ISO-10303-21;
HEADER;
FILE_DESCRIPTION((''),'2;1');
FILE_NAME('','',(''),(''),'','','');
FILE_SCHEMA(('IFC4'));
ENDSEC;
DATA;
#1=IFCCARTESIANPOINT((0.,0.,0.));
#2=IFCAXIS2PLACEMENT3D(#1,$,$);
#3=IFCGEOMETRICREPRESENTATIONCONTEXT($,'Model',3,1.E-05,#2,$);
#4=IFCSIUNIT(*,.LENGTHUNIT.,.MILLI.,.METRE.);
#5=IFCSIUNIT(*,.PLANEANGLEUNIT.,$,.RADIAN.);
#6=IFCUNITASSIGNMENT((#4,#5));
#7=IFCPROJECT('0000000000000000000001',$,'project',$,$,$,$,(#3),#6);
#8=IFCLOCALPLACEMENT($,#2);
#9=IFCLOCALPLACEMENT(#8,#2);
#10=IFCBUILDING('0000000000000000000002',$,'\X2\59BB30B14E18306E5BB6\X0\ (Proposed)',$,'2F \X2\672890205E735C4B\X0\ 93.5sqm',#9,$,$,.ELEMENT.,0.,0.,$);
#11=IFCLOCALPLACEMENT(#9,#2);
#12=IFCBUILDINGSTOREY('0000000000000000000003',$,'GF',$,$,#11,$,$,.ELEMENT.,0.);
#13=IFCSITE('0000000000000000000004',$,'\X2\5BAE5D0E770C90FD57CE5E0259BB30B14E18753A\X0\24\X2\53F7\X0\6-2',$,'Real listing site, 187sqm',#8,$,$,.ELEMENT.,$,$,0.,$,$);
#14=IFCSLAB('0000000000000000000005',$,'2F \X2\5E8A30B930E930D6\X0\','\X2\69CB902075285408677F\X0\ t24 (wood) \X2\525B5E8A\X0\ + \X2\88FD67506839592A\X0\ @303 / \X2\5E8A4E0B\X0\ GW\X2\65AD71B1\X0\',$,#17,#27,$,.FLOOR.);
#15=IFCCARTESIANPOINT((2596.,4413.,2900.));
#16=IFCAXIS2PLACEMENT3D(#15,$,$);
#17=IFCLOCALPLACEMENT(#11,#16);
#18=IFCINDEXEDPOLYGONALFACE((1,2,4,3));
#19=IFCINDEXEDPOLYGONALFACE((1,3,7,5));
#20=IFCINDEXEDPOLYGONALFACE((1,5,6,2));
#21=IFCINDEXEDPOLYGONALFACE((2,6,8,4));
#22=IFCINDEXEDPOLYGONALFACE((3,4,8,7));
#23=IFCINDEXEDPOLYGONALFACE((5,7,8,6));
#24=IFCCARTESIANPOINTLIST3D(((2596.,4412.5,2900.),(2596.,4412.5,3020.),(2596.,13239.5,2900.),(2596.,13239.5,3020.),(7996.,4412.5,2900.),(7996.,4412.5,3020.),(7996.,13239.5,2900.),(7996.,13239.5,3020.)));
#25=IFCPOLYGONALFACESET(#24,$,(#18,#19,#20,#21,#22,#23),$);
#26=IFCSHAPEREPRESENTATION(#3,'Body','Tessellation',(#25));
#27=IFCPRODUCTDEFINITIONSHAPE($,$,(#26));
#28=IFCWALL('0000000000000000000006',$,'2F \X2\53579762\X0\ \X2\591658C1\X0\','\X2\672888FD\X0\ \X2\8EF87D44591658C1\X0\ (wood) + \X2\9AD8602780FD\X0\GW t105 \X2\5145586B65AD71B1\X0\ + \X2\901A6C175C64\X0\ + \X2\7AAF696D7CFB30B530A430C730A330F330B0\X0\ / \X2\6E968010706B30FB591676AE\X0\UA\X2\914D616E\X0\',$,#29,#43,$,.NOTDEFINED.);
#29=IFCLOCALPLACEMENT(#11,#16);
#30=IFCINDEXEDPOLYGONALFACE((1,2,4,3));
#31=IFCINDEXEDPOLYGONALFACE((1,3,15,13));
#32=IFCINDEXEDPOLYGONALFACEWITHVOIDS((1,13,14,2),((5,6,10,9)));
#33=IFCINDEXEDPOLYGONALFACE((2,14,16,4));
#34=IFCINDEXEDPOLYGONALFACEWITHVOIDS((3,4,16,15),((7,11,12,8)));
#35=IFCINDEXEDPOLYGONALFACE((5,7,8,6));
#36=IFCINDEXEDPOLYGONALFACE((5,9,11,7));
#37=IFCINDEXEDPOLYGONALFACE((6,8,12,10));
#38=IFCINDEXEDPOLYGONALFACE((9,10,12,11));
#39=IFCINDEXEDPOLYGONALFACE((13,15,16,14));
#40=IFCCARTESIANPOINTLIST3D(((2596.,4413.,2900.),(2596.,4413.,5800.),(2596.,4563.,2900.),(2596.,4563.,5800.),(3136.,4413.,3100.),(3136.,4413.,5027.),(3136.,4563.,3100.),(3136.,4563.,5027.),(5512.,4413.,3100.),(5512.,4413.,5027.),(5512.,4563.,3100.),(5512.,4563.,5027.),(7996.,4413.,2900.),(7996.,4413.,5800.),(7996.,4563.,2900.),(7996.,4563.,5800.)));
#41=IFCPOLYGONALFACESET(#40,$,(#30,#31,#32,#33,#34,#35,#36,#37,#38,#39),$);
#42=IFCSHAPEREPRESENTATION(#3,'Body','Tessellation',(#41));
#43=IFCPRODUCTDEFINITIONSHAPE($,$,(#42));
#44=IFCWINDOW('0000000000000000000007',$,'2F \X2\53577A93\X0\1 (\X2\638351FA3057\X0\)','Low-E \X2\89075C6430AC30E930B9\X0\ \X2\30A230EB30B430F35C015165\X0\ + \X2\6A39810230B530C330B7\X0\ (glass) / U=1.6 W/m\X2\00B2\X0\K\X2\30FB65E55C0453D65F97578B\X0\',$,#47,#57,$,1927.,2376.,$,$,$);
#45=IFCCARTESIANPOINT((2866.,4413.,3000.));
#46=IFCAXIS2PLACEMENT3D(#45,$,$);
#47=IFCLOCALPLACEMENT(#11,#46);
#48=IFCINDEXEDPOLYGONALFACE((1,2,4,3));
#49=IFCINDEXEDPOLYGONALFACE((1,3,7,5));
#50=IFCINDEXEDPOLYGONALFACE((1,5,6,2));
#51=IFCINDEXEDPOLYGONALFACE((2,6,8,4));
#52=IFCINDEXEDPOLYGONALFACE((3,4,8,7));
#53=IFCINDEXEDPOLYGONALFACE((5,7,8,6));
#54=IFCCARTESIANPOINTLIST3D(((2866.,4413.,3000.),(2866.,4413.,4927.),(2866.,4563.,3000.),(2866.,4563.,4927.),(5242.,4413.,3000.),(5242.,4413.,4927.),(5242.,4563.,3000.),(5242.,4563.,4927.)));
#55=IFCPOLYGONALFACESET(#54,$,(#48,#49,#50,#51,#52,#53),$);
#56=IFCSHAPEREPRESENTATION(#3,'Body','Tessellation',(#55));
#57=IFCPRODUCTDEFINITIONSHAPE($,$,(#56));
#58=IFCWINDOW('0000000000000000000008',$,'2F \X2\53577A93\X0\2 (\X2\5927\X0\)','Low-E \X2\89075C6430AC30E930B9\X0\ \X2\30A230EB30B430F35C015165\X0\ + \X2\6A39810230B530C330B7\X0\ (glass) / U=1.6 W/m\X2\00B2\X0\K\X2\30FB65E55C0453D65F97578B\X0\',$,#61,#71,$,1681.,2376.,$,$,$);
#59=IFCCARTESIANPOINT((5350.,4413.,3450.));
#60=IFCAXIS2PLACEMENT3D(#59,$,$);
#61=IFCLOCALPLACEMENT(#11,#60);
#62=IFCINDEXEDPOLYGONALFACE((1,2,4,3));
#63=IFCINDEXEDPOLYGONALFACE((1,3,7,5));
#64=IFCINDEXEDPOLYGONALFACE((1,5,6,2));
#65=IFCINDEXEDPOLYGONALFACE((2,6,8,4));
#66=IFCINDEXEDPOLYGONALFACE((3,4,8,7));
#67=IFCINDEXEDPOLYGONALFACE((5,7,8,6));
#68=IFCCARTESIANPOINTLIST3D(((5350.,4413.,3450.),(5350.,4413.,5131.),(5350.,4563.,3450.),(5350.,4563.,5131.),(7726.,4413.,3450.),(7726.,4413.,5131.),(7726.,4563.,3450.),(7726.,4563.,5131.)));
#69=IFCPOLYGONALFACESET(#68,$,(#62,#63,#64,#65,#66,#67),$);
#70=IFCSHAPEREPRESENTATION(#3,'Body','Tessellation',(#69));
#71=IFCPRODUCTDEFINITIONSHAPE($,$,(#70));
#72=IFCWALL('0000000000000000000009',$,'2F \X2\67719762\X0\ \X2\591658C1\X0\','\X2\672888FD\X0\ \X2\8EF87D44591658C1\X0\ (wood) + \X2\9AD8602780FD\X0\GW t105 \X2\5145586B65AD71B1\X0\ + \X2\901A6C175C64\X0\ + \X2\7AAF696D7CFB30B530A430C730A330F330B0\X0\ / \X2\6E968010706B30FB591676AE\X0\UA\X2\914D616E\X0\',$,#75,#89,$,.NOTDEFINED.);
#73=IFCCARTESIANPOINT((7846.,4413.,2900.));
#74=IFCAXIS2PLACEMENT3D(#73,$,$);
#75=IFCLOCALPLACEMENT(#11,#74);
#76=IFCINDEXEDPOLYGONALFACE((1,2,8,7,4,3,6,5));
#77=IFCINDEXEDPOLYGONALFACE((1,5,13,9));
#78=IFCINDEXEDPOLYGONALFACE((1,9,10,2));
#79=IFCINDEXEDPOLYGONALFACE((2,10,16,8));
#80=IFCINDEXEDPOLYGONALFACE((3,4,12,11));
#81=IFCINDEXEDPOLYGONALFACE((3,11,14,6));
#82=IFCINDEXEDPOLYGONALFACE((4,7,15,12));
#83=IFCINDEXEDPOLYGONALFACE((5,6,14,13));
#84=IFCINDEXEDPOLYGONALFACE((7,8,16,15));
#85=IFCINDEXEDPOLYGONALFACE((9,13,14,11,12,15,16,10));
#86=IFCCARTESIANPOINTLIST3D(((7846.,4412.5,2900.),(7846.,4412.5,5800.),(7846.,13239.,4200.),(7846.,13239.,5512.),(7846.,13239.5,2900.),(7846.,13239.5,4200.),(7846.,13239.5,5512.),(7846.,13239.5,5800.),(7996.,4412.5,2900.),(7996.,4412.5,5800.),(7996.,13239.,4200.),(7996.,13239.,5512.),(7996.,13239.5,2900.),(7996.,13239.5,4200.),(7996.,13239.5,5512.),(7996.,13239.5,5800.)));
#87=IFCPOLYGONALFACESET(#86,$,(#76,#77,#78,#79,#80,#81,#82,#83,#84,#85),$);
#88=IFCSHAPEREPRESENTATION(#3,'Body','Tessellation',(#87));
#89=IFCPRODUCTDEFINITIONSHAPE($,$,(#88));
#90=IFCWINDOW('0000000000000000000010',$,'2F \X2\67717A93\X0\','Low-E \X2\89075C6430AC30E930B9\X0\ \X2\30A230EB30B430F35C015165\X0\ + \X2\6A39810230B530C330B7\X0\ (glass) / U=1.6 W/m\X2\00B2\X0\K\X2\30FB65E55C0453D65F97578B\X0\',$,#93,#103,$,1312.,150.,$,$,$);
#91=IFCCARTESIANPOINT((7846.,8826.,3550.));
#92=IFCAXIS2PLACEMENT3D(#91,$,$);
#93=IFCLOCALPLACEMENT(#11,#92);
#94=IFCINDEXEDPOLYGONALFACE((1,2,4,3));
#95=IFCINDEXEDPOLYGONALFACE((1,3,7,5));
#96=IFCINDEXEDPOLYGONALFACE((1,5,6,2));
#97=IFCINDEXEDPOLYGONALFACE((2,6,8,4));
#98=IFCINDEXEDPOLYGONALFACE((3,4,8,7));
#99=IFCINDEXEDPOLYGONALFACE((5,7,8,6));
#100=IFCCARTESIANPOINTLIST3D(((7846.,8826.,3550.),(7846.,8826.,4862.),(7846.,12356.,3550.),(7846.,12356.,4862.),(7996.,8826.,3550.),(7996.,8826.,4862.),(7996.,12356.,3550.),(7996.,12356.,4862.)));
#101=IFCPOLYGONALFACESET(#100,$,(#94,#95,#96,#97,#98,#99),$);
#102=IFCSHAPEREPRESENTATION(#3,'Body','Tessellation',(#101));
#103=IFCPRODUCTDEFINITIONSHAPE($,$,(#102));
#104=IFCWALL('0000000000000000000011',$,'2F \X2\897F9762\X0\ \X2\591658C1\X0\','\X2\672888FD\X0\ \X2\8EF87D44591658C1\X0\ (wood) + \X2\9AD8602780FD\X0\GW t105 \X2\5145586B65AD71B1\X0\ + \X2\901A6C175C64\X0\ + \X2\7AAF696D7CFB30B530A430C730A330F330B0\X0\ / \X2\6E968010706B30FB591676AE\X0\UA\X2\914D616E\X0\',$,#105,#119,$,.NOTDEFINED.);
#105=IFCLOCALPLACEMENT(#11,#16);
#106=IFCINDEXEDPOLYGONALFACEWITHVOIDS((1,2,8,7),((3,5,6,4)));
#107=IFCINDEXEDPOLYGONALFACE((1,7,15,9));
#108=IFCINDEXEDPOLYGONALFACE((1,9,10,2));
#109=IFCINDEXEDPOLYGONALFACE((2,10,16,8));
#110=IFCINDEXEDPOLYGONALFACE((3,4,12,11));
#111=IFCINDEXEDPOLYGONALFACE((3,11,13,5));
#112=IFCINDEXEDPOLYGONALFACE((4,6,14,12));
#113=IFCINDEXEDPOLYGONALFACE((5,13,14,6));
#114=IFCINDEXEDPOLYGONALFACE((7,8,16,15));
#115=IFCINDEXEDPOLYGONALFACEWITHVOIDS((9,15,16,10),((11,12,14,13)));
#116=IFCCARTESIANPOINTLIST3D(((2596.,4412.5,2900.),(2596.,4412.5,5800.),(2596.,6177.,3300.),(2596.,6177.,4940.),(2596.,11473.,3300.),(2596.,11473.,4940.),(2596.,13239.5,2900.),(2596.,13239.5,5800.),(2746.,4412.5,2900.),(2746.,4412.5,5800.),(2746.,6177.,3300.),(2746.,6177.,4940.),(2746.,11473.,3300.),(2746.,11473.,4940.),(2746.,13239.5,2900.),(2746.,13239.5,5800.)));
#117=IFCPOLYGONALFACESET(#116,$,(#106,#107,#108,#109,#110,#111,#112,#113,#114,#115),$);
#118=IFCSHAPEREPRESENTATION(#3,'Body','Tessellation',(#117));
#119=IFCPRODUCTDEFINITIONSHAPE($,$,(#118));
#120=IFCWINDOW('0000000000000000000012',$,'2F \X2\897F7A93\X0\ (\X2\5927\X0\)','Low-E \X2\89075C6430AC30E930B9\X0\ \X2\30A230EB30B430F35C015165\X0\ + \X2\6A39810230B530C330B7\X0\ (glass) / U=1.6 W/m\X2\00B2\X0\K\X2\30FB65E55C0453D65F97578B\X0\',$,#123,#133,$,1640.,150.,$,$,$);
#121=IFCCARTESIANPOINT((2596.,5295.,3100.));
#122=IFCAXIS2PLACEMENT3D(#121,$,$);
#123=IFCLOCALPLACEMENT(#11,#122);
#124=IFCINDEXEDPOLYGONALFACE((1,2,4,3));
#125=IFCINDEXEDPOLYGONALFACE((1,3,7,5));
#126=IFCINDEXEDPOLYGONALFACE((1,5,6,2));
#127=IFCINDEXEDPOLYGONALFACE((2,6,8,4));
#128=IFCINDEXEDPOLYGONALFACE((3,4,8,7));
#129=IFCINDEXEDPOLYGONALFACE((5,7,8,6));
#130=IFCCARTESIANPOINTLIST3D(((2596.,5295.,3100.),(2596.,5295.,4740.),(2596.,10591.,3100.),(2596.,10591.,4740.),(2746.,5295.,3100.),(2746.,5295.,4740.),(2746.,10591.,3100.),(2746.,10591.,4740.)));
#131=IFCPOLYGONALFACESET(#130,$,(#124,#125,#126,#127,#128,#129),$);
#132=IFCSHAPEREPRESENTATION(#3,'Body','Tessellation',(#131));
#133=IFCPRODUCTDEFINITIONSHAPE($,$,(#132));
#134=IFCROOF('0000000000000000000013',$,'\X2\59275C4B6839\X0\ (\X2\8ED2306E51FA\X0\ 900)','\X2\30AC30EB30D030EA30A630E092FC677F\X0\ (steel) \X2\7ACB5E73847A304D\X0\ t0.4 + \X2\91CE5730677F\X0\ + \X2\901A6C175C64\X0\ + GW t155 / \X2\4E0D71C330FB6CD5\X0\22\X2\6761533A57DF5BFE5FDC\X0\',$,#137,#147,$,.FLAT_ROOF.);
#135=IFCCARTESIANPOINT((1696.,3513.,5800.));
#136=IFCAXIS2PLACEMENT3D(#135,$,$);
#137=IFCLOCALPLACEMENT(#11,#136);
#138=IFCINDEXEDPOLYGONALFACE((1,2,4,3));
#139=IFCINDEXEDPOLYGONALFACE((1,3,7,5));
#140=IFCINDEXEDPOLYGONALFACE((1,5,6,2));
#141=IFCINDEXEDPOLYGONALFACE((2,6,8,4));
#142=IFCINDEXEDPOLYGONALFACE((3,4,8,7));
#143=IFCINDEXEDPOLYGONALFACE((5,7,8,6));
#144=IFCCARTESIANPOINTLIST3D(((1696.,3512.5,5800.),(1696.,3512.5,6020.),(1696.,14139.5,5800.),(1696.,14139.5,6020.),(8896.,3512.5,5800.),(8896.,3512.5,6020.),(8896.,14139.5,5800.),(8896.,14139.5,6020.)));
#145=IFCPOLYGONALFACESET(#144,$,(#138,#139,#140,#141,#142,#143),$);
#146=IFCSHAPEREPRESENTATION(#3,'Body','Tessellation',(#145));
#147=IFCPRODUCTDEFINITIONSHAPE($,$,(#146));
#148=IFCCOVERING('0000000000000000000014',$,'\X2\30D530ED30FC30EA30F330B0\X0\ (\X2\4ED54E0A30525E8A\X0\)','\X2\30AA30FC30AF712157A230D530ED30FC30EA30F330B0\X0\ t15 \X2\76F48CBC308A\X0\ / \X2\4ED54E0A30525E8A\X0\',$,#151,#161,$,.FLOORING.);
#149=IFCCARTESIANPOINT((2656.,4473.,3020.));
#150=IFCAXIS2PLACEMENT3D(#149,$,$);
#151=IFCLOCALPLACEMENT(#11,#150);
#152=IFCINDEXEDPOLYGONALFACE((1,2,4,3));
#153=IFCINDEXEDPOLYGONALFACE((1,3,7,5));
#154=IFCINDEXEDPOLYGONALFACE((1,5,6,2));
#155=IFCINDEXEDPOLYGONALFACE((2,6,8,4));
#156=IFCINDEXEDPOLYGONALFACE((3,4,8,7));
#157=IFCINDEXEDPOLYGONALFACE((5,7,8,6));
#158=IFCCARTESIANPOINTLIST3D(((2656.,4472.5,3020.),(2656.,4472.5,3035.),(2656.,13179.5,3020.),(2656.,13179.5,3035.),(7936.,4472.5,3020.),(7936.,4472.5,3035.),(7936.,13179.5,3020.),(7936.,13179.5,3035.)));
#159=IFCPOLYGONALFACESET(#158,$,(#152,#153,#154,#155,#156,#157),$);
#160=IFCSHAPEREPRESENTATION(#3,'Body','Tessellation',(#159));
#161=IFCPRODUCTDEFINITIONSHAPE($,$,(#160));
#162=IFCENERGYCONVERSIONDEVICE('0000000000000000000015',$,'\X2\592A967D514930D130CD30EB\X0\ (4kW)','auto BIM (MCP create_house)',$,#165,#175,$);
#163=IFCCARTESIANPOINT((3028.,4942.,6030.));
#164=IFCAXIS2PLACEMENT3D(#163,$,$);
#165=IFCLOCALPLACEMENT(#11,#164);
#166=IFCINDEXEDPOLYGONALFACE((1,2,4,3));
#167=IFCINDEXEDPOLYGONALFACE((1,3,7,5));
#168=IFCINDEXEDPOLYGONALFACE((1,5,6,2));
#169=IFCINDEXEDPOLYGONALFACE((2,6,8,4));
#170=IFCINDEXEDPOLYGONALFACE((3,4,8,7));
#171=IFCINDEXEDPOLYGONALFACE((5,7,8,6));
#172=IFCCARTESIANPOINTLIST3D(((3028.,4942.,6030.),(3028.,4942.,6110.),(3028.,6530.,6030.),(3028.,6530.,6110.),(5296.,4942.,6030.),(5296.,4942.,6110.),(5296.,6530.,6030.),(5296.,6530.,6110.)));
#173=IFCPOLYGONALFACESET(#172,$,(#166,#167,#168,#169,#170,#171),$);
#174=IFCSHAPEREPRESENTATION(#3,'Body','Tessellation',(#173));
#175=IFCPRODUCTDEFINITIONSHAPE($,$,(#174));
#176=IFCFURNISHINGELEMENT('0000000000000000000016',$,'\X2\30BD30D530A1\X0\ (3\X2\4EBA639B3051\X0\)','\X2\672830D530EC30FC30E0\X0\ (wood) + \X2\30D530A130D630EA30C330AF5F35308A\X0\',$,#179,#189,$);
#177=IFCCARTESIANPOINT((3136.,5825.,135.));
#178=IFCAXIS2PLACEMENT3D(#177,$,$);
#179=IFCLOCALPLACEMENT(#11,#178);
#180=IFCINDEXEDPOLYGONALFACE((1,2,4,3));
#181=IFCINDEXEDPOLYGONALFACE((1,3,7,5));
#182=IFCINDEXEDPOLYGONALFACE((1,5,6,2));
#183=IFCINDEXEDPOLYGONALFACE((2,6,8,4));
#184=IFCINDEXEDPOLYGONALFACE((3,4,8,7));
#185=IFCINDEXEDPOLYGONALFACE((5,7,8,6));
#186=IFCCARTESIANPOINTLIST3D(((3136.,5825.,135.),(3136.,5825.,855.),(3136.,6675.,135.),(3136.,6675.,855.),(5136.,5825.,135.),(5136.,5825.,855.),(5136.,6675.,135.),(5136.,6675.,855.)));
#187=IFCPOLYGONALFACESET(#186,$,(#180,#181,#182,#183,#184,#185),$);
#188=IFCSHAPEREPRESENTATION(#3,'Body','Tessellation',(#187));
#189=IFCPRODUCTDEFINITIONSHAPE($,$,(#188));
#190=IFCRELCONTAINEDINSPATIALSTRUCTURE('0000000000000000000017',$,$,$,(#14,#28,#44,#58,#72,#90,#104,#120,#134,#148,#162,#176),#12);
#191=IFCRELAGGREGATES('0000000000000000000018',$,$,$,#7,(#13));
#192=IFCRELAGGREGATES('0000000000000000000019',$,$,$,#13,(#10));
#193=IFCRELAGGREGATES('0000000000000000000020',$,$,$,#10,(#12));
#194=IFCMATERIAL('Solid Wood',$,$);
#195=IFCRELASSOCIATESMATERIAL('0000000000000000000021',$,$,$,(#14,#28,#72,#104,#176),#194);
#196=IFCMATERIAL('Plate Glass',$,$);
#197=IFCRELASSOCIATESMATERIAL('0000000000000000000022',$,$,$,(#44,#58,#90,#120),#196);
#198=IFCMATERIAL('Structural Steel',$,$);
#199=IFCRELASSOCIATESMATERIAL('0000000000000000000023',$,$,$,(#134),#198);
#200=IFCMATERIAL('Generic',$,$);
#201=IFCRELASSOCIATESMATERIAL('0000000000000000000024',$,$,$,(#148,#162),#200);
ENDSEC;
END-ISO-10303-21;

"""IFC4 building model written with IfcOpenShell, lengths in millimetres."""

from ifc_helpers import new_model, si_unit, frame, frame_2d, origin, place, context, project, spatial, rectangle, extrude, material, element, fill, save


model = new_model("IFC4")

# Units and contexts
model_context = context("Model", 3, precision=1e-05, world=origin())
ifc_project = project(units=[si_unit("LENGTHUNIT", "METRE", prefix="MILLI"), si_unit("PLANEANGLEUNIT", "RADIAN")], contexts=[model_context])

# Site, building, storey
site_placement = place(None, origin())
site = spatial("IfcSite", under=ifc_project, at=site_placement, Name="宮崎県都城市妻ケ丘町24号6-2", ObjectType="Real listing site, 187sqm", CompositionType="ELEMENT", RefElevation=0.0)
building_placement = place(site_placement, origin())
building = spatial("IfcBuilding", under=site, at=building_placement, Name="妻ケ丘の家 (Proposed)", ObjectType="2F 木造平屋 93.5sqm", CompositionType="ELEMENT", ElevationOfRefHeight=0.0, ElevationOfTerrain=0.0)
storey_placement = place(building_placement, origin())
storey = spatial("IfcBuildingStorey", under=building, at=storey_placement, Name="GF", CompositionType="ELEMENT", Elevation=0.0)

# Slab
ifc_material_1 = material(Name="Solid Wood")
slab_placement = place(storey_placement, frame((2596.0, 4413.0, 2900.0)))
element("IfcSlab", 1, at=slab_placement, inside=storey, material=ifc_material_1, Name="2F 床スラブ", Description="構造用合板 t24 (wood) 剛床 + 製材根太 @303 / 床下 GW断熱", PredefinedType="FLOOR", context=model_context, shape_type="SweptSolid", body=[
    extrude(rectangle(XDim=5400.0, YDim=8827.0, at=frame_2d((2700.0, 4413.0))), frame((2596.0, 4413.0, 2900.0)), (0.0, 0.0, 1.0), 120.0),
])

# Wall, openings, windows
wall_1_placement = place(storey_placement, frame((2596.0, 4413.0, 2900.0)))
wall_1 = element("IfcWall", 2, at=wall_1_placement, inside=storey, material=ifc_material_1, Name="2F 南面 外壁", Description="木製 軸組外壁 (wood) + 高性能GW t105 充填断熱 + 通気層 + 窯業系サイディング / 準耐火・外皮UA配慮", PredefinedType="NOTDEFINED", context=model_context, shape_type="SweptSolid", body=[
    extrude(rectangle(XDim=5400.0, YDim=150.0, at=frame_2d((2700.0, 75.0))), frame((2596.0, 4413.0, 2900.0)), (0.0, 0.0, 1.0), 2900.0),
])
opening_1_placement = place(storey_placement, frame((2866.0, 4413.0, 3000.0)))
opening_1 = element("IfcOpeningElement", 3, at=opening_1_placement, cuts=wall_1, PredefinedType="NOTDEFINED", context=model_context, shape_type="SweptSolid", body=[
    extrude(rectangle(XDim=2376.0, YDim=150.0, at=frame_2d((1188.0, 75.0))), frame((2866.0, 4413.0, 3000.0)), (0.0, 0.0, 1.0), 1927.0),
])
opening_2_placement = place(storey_placement, frame((5350.0, 4413.0, 3450.0)))
opening_2 = element("IfcOpeningElement", 4, at=opening_2_placement, cuts=wall_1, PredefinedType="NOTDEFINED", context=model_context, shape_type="SweptSolid", body=[
    extrude(rectangle(XDim=2376.0, YDim=150.0, at=frame_2d((1188.0, 75.0))), frame((5350.0, 4413.0, 3450.0)), (0.0, 0.0, 1.0), 1681.0),
])
ifc_material_2 = material(Name="Plate Glass")
window_1_placement = place(storey_placement, frame((2866.0, 4413.0, 3000.0)))
window_1 = element("IfcWindow", 5, at=window_1_placement, inside=storey, material=ifc_material_2, Name="2F 南窓1 (掃出し)", Description="Low-E 複層ガラス アルゴン封入 + 樹脂サッシ (glass) / U=1.6 W/m²K・日射取得型", OverallHeight=1927.0, OverallWidth=2376.0, context=model_context, shape_type="SweptSolid", body=[
    extrude(rectangle(XDim=2376.0, YDim=150.0, at=frame_2d((1188.0, 75.0))), frame((2866.0, 4413.0, 3000.0)), (0.0, 0.0, 1.0), 1927.0),
])
fill(opening_1, window_1)
window_2_placement = place(storey_placement, frame((5350.0, 4413.0, 3450.0)))
window_2 = element("IfcWindow", 6, at=window_2_placement, inside=storey, material=ifc_material_2, Name="2F 南窓2 (大)", Description="Low-E 複層ガラス アルゴン封入 + 樹脂サッシ (glass) / U=1.6 W/m²K・日射取得型", OverallHeight=1681.0, OverallWidth=2376.0, context=model_context, shape_type="SweptSolid", body=[
    extrude(rectangle(XDim=2376.0, YDim=150.0, at=frame_2d((1188.0, 75.0))), frame((5350.0, 4413.0, 3450.0)), (0.0, 0.0, 1.0), 1681.0),
])
fill(opening_2, window_2)

# Walls, openings, windows
wall_2_placement = place(storey_placement, frame((7846.0, 4413.0, 2900.0)))
wall_2 = element("IfcWall", 7, at=wall_2_placement, inside=storey, material=ifc_material_1, Name="2F 東面 外壁", Description="木製 軸組外壁 (wood) + 高性能GW t105 充填断熱 + 通気層 + 窯業系サイディング / 準耐火・外皮UA配慮", PredefinedType="NOTDEFINED", context=model_context, shape_type="SweptSolid", body=[
    extrude(rectangle(XDim=150.0, YDim=8827.0, at=frame_2d((75.0, 4413.0))), frame((7846.0, 4413.0, 2900.0)), (0.0, 0.0, 1.0), 2900.0),
])
opening_3_placement = place(storey_placement, frame((7846.0, 8826.0, 3550.0)))
opening_3 = element("IfcOpeningElement", 8, at=opening_3_placement, cuts=wall_2, PredefinedType="NOTDEFINED", context=model_context, shape_type="SweptSolid", body=[
    extrude(rectangle(XDim=150.0, YDim=3530.0, at=frame_2d((75.0, 1765.0))), frame((7846.0, 8826.0, 3550.0)), (0.0, 0.0, 1.0), 1312.0),
])
window_3_placement = place(storey_placement, frame((7846.0, 8826.0, 3550.0)))
window_3 = element("IfcWindow", 9, at=window_3_placement, inside=storey, material=ifc_material_2, Name="2F 東窓", Description="Low-E 複層ガラス アルゴン封入 + 樹脂サッシ (glass) / U=1.6 W/m²K・日射取得型", OverallHeight=1312.0, OverallWidth=150.0, context=model_context, shape_type="SweptSolid", body=[
    extrude(rectangle(XDim=150.0, YDim=3530.0, at=frame_2d((75.0, 1765.0))), frame((7846.0, 8826.0, 3550.0)), (0.0, 0.0, 1.0), 1312.0),
])
fill(opening_3, window_3)
wall_3_placement = place(storey_placement, frame((2596.0, 4413.0, 2900.0)))
wall_3 = element("IfcWall", 10, at=wall_3_placement, inside=storey, material=ifc_material_1, Name="2F 西面 外壁", Description="木製 軸組外壁 (wood) + 高性能GW t105 充填断熱 + 通気層 + 窯業系サイディング / 準耐火・外皮UA配慮", PredefinedType="NOTDEFINED", context=model_context, shape_type="SweptSolid", body=[
    extrude(rectangle(XDim=150.0, YDim=8827.0, at=frame_2d((75.0, 4413.0))), frame((2596.0, 4413.0, 2900.0)), (0.0, 0.0, 1.0), 2900.0),
])
opening_4_placement = place(storey_placement, frame((2596.0, 5295.0, 3100.0)))
opening_4 = element("IfcOpeningElement", 11, at=opening_4_placement, cuts=wall_3, PredefinedType="NOTDEFINED", context=model_context, shape_type="SweptSolid", body=[
    extrude(rectangle(XDim=150.0, YDim=5296.0, at=frame_2d((75.0, 2648.0))), frame((2596.0, 5295.0, 3100.0)), (0.0, 0.0, 1.0), 1640.0),
])
window_4_placement = place(storey_placement, frame((2596.0, 5295.0, 3100.0)))
window_4 = element("IfcWindow", 12, at=window_4_placement, inside=storey, material=ifc_material_2, Name="2F 西窓 (大)", Description="Low-E 複層ガラス アルゴン封入 + 樹脂サッシ (glass) / U=1.6 W/m²K・日射取得型", OverallHeight=1640.0, OverallWidth=150.0, context=model_context, shape_type="SweptSolid", body=[
    extrude(rectangle(XDim=150.0, YDim=5296.0, at=frame_2d((75.0, 2648.0))), frame((2596.0, 5295.0, 3100.0)), (0.0, 0.0, 1.0), 1640.0),
])
fill(opening_4, window_4)

# Roof
ifc_material_3 = material(Name="Structural Steel")
roof_placement = place(storey_placement, frame((1696.0, 3513.0, 5800.0)))
element("IfcRoof", 13, at=roof_placement, inside=storey, material=ifc_material_3, Name="大屋根 (軒の出 900)", Description="ガルバリウム鋼板 (steel) 立平葺き t0.4 + 野地板 + 通気層 + GW t155 / 不燃・法22条区域対応", PredefinedType="FLAT_ROOF", context=model_context, shape_type="SweptSolid", body=[
    extrude(rectangle(XDim=7200.0, YDim=10627.0, at=frame_2d((3600.0, 5313.0))), frame((1696.0, 3513.0, 5800.0)), (0.0, 0.0, 1.0), 220.0),
])

# Covering
ifc_material_4 = material(Name="Generic")
covering_placement = place(storey_placement, frame((2656.0, 4473.0, 3020.0)))
element("IfcCovering", 14, at=covering_placement, inside=storey, material=ifc_material_4, Name="フローリング (仕上げ床)", Description="オーク無垢フローリング t15 直貼り / 仕上げ床", PredefinedType="FLOORING", context=model_context, shape_type="SweptSolid", body=[
    extrude(rectangle(XDim=5280.0, YDim=8707.0, at=frame_2d((2640.0, 4353.0))), frame((2656.0, 4473.0, 3020.0)), (0.0, 0.0, 1.0), 15.0),
])

# Energy conversion device
energy_conversion_device_placement = place(storey_placement, frame((3028.0, 4942.0, 6030.0)))
element("IfcEnergyConversionDevice", 15, at=energy_conversion_device_placement, inside=storey, material=ifc_material_4, Name="太陽光パネル (4kW)", Description="auto BIM (MCP create_house)", context=model_context, shape_type="SweptSolid", body=[
    extrude(rectangle(XDim=2268.0, YDim=1588.0, at=frame_2d((1134.0, 794.0))), frame((3028.0, 4942.0, 6030.0)), (0.0, 0.0, 1.0), 80.0),
])

# Furnishing element
furnishing_1_placement = place(storey_placement, frame((3136.0, 5825.0, 135.0)))
element("IfcFurnishingElement", 16, at=furnishing_1_placement, inside=storey, material=ifc_material_1, Name="ソファ (3人掛け)", Description="木フレーム (wood) + ファブリック張り", context=model_context, shape_type="SweptSolid", body=[
    extrude(rectangle(XDim=2000.0, YDim=850.0, at=frame_2d((1000.0, 425.0))), frame((3136.0, 5825.0, 135.0)), (0.0, 0.0, 1.0), 720.0),
])

save(model, "model.ifc")
